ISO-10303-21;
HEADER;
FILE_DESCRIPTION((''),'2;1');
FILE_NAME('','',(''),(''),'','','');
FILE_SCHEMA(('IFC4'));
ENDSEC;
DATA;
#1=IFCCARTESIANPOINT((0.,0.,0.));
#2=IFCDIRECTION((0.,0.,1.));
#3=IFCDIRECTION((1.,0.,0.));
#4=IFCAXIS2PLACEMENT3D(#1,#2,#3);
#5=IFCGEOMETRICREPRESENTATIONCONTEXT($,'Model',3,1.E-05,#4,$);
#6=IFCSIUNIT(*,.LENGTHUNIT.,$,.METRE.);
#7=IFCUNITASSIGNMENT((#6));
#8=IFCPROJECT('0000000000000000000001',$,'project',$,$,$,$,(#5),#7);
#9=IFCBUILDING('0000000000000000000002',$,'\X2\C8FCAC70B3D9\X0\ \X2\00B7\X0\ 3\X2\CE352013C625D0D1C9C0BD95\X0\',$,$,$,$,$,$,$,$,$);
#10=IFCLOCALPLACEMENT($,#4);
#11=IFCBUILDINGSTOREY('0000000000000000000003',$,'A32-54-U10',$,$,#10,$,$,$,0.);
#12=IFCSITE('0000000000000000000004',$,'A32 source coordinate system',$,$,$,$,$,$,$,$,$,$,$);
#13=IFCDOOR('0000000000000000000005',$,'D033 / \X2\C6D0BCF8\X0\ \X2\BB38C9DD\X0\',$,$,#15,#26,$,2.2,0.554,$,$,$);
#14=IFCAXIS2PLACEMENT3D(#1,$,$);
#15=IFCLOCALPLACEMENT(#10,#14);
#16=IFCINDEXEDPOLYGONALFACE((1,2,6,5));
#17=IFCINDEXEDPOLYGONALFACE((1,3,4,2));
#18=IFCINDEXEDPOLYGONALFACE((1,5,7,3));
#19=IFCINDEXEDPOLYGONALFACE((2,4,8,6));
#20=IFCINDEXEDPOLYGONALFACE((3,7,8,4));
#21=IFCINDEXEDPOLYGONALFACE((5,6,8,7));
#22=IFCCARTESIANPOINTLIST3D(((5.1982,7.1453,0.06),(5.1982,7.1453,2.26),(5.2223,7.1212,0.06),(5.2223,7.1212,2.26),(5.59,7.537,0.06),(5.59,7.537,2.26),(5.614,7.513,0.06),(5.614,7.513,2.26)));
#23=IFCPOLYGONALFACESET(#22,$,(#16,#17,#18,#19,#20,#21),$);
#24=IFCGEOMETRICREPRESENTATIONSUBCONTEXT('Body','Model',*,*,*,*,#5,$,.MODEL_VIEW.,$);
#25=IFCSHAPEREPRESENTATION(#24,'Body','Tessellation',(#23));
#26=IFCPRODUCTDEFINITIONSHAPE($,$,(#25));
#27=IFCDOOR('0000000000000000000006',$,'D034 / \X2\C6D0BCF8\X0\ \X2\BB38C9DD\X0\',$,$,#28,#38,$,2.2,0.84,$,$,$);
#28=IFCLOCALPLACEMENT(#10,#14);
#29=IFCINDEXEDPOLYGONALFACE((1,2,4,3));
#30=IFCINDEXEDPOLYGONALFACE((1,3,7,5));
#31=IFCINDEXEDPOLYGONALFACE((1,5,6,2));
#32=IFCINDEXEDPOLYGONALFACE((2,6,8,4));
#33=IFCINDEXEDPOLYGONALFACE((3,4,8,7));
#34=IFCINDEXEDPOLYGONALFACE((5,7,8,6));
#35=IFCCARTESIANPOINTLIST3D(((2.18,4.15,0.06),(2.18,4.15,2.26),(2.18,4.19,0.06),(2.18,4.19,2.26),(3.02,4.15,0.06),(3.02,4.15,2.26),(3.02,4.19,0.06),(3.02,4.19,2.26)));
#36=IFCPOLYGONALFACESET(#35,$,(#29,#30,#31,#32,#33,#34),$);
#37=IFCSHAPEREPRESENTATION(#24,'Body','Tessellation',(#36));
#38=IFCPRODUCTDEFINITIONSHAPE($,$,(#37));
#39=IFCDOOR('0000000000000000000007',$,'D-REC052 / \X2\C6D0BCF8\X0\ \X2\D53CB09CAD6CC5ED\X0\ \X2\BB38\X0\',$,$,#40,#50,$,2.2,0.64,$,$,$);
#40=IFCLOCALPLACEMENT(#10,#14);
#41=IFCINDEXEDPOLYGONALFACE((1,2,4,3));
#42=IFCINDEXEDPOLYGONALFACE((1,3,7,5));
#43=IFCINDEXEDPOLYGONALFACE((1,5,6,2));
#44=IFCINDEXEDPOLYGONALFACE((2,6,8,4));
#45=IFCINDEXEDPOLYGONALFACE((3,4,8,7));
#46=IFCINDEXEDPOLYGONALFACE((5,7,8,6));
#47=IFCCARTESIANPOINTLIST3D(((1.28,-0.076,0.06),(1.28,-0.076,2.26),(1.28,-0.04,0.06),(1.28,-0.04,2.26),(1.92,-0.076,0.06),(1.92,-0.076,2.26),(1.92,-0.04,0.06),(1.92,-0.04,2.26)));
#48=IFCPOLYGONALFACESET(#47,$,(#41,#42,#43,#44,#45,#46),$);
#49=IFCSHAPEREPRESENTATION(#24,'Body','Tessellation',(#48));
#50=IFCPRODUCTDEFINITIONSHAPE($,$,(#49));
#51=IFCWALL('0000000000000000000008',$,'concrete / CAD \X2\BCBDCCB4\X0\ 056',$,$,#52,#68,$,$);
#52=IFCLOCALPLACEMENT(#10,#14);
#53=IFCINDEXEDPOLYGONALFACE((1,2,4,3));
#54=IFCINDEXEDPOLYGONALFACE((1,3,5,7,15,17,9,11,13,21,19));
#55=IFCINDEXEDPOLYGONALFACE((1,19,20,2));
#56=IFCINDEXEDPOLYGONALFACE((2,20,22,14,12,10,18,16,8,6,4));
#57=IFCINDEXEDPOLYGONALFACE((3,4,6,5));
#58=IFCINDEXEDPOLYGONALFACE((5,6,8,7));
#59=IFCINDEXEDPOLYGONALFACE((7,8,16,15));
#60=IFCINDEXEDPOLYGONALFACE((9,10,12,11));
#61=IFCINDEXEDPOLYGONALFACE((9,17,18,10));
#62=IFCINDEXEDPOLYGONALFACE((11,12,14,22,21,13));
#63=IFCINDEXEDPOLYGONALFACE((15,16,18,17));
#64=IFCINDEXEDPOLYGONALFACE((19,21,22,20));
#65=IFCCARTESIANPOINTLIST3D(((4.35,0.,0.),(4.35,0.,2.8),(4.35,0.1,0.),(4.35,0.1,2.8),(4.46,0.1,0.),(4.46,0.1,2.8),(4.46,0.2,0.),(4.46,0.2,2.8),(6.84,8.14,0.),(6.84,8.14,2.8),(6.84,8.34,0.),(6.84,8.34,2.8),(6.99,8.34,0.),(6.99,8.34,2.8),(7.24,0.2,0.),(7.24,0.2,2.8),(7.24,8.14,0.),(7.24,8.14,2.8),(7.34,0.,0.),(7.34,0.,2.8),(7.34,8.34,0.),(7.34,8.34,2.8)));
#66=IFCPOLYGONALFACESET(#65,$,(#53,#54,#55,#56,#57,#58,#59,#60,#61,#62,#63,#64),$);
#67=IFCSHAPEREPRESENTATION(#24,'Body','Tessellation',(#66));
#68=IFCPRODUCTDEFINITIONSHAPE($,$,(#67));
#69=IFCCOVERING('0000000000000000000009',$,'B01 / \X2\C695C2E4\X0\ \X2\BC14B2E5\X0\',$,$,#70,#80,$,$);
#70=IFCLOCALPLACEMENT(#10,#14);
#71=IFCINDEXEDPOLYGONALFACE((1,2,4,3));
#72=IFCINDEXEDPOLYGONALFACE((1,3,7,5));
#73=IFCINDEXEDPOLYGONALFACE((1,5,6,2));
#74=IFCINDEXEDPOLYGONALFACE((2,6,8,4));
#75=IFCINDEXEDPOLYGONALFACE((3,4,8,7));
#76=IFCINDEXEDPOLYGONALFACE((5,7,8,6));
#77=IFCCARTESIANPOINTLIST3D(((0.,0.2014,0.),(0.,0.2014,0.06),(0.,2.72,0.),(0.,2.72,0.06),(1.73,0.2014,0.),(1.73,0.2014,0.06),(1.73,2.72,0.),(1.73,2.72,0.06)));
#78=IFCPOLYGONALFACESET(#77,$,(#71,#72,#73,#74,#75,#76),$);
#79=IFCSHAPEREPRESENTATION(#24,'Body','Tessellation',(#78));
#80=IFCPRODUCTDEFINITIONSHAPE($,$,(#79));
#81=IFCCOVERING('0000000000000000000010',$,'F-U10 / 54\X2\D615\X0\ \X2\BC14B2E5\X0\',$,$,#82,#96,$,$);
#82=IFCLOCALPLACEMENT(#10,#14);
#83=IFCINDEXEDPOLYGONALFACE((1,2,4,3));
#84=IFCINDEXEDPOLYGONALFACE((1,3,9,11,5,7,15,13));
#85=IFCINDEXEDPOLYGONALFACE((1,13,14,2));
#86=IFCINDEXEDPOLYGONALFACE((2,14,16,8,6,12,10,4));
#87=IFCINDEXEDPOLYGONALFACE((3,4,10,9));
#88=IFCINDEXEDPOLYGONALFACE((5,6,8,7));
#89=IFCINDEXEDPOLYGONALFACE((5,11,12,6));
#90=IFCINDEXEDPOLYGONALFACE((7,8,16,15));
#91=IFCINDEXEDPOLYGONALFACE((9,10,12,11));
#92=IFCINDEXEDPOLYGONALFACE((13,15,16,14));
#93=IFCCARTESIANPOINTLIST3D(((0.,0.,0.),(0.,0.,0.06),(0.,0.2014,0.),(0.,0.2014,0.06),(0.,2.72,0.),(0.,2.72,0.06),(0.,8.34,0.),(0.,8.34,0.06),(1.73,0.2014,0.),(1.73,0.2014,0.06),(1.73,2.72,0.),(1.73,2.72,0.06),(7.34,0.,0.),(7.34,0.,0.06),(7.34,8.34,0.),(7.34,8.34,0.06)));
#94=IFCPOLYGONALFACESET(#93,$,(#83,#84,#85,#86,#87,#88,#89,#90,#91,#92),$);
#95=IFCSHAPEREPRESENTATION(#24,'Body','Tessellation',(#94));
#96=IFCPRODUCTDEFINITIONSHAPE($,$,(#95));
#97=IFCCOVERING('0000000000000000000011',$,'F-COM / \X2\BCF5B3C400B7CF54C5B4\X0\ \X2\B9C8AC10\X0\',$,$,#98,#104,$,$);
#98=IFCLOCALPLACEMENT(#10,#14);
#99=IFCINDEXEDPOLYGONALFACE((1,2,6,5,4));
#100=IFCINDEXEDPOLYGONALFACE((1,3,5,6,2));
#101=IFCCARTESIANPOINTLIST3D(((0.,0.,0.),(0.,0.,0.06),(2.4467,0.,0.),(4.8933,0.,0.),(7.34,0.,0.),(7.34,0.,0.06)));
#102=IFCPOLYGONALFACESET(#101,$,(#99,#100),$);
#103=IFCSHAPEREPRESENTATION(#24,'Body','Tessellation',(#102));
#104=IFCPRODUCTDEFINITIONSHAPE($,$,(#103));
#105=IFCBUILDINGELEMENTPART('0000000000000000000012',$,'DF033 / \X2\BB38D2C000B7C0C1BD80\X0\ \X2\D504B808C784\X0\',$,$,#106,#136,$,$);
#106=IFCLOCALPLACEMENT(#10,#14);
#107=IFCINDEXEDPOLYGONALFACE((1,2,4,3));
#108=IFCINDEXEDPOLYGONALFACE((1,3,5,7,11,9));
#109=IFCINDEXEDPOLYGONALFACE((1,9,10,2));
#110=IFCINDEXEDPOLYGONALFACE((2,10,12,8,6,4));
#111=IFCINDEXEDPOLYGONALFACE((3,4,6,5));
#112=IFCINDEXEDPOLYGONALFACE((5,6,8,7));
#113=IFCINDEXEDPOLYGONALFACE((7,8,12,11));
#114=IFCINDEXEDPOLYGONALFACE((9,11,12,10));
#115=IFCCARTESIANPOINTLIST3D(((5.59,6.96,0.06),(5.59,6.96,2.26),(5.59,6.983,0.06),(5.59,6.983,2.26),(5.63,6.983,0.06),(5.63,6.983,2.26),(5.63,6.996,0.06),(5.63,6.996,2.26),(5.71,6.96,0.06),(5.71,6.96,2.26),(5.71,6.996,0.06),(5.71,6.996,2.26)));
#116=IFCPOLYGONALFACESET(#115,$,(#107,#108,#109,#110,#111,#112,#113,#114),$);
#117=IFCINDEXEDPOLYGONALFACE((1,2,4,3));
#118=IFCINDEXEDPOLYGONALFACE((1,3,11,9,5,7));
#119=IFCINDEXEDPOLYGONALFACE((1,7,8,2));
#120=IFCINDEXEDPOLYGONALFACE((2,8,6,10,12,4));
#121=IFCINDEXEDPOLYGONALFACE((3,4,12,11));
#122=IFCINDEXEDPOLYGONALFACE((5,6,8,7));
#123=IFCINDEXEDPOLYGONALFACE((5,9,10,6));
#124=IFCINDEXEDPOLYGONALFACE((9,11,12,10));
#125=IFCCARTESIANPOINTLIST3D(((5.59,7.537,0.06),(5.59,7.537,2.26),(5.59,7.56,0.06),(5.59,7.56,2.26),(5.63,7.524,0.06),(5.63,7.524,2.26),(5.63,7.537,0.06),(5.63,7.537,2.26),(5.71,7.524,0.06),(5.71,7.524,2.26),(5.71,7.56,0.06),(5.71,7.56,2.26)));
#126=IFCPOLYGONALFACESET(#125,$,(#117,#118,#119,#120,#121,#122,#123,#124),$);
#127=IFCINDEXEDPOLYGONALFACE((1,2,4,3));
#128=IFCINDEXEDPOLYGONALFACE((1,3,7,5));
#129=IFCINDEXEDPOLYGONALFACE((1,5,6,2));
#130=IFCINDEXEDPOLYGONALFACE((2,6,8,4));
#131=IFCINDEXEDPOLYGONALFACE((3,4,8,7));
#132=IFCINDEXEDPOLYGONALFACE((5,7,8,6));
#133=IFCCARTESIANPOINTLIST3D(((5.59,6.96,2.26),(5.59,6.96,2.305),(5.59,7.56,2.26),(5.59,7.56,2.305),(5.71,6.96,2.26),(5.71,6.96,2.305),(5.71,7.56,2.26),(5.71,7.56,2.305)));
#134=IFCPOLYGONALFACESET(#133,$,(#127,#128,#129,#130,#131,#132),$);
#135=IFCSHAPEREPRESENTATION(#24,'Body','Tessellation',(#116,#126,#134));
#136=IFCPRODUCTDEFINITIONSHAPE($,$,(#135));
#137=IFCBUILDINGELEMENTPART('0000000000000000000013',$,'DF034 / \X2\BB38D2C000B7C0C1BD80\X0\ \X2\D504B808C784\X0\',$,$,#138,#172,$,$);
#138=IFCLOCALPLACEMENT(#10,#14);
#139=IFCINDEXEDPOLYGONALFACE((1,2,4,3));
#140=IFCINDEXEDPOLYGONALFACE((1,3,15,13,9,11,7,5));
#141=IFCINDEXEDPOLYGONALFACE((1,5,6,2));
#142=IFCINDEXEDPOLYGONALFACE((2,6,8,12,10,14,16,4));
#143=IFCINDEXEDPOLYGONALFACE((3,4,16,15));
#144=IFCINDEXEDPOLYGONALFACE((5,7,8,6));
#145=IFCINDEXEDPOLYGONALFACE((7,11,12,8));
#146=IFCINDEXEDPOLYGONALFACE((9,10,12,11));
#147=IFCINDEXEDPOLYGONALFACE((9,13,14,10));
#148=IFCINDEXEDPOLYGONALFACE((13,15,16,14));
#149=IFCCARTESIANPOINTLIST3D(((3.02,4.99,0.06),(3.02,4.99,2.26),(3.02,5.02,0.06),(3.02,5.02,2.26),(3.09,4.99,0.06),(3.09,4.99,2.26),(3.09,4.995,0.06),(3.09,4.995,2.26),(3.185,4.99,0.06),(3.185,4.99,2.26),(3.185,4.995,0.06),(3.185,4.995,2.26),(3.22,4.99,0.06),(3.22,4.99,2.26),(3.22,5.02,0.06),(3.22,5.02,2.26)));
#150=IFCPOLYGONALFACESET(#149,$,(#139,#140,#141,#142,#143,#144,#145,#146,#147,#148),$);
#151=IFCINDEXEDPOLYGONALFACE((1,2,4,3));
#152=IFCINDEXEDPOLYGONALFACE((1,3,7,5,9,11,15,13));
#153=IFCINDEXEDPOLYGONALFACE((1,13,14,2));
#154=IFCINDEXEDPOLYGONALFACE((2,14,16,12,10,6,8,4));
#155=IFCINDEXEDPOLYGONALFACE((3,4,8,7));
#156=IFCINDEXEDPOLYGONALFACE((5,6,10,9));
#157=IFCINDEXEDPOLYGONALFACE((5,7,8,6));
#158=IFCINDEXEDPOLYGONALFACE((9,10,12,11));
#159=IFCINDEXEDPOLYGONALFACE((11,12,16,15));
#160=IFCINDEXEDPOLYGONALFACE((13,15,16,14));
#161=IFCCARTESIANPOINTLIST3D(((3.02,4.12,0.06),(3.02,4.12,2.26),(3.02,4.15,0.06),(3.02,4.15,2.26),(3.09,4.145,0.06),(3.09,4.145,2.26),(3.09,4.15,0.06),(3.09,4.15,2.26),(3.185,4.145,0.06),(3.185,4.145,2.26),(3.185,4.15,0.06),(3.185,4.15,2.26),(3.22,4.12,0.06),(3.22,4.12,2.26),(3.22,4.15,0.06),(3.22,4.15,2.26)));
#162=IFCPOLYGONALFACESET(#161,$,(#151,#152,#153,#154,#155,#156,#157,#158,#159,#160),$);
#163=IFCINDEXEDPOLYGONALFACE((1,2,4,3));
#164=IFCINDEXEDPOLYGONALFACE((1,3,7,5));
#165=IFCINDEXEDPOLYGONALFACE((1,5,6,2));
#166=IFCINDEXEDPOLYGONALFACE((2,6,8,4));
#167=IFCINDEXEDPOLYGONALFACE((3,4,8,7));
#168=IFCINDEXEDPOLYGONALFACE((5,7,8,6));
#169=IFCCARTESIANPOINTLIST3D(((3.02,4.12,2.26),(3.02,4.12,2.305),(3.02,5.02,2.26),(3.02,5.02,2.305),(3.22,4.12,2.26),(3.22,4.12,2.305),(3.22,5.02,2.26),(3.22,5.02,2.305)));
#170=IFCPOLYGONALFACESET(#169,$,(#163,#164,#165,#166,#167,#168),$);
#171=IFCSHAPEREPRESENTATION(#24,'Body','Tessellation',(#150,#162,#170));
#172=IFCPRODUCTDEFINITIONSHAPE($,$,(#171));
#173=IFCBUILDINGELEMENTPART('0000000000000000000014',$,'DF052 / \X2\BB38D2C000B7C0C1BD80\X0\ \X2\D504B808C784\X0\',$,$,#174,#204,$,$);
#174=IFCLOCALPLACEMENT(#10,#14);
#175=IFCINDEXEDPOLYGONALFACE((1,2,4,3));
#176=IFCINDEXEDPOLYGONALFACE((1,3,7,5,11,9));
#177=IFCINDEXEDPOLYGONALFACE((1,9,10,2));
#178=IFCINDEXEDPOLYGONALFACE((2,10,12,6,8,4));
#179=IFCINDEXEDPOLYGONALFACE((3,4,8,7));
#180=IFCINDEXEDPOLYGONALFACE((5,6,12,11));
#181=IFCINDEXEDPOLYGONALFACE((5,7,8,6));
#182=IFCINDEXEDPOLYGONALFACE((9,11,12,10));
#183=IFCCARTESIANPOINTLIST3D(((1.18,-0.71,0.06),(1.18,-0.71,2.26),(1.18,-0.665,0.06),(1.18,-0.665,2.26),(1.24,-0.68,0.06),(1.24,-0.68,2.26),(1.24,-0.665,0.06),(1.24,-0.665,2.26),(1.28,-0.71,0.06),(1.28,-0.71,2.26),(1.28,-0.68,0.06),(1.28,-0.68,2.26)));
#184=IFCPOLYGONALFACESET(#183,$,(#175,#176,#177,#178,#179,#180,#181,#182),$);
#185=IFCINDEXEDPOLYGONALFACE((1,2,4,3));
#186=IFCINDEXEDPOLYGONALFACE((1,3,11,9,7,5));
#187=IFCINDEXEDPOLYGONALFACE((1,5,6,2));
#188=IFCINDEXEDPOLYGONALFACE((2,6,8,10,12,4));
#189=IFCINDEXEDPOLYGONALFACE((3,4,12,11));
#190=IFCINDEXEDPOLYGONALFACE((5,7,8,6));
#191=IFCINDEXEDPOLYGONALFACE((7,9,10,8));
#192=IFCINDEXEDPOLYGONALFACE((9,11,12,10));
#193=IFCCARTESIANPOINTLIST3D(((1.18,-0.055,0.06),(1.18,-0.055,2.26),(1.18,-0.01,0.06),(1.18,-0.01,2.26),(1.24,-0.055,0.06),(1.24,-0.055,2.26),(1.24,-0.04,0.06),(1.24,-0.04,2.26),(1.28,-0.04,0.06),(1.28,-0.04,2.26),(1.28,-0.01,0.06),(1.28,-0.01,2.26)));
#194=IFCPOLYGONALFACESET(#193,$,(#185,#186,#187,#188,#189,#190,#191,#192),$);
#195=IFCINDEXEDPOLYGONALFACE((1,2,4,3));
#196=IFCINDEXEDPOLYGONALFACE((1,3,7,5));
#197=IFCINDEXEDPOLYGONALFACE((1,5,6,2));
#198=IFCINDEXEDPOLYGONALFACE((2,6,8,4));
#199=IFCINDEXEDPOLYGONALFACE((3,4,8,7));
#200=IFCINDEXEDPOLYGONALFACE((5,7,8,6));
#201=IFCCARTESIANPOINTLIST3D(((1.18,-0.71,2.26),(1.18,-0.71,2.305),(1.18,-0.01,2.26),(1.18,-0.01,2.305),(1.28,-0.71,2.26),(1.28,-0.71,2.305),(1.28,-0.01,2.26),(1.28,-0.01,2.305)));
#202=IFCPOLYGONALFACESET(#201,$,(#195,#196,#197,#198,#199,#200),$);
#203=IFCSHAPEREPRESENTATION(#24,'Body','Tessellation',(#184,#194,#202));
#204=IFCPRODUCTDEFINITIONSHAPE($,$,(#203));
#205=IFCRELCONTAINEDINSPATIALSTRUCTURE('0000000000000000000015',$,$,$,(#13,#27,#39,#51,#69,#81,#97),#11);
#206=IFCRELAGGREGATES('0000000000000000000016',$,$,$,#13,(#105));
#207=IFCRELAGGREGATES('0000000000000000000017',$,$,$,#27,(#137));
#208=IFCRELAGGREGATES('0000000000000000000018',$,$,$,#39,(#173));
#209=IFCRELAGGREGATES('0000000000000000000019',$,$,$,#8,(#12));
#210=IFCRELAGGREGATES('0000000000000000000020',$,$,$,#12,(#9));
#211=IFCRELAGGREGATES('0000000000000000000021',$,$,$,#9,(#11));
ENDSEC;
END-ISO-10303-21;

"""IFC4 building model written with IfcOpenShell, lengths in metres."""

from ifc_helpers import new_model, si_unit, frame, origin, origin_with_axes, place, context, subcontext, project, spatial, polyline, outline, extrude, element, aggregate, save


model = new_model("IFC4")

# Units and contexts
model_context = context("Model", 3, precision=1e-05, world=origin_with_axes())
body_context = subcontext(model_context, "Body", "Model", "MODEL_VIEW")
ifc_project = project(units=[si_unit("LENGTHUNIT", "METRE")], contexts=[model_context])

# Site, building, storey
storey_placement = place(None, origin_with_axes())
site = spatial("IfcSite", under=ifc_project, Name="A32 source coordinate system")
building = spatial("IfcBuilding", under=site, Name="주거동 · 3층–옥탑지붕")
storey = spatial("IfcBuildingStorey", under=building, at=storey_placement, Name="A32-54-U10", Elevation=0.0)

# Doors
door_1_placement = place(storey_placement, origin_with_axes())
door_1 = element("IfcDoor", 1, at=door_1_placement, inside=storey, Name="D033 / 원본 문짝", OverallHeight=2.2, OverallWidth=0.554, context=body_context, shape_type="SweptSolid", body=[
    extrude(outline(polyline([(5.2223, 7.1212), (5.1982, 7.1453), (5.59, 7.537), (5.614, 7.513), (5.2223, 7.1212)])), frame((0.0, 0.0, 0.06)), (0.0, 0.0, 1.0), 2.2),
])
door_2_placement = place(storey_placement, origin_with_axes())
door_2 = element("IfcDoor", 2, at=door_2_placement, inside=storey, Name="D034 / 원본 문짝", OverallHeight=2.2, OverallWidth=0.84, context=body_context, shape_type="SweptSolid", body=[
    extrude(outline(polyline([(3.02, 4.15), (2.18, 4.15), (2.18, 4.19), (3.02, 4.19), (3.02, 4.15)])), frame((0.0, 0.0, 0.06)), (0.0, 0.0, 1.0), 2.2),
])
door_3_placement = place(storey_placement, origin_with_axes())
door_3 = element("IfcDoor", 3, at=door_3_placement, inside=storey, Name="D-REC052 / 원본 피난구역 문", OverallHeight=2.2, OverallWidth=0.64, context=body_context, shape_type="SweptSolid", body=[
    extrude(outline(polyline([(1.92, -0.076), (1.28, -0.076), (1.28, -0.04), (1.92, -0.04), (1.92, -0.076)])), frame((0.0, 0.0, 0.06)), (0.0, 0.0, 1.0), 2.2),
])

# Wall
wall_placement = place(storey_placement, origin_with_axes())
element("IfcWall", 4, at=wall_placement, inside=storey, Name="concrete / CAD 벽체 056", context=body_context, shape_type="SweptSolid", body=[
    extrude(outline(polyline([(7.24, 0.2), (7.24, 8.14), (6.84, 8.14), (6.84, 8.34), (6.99, 8.34), (6.99, 8.34), (7.34, 8.34), (7.34, 0.0), (4.35, 0.0), (4.35, 0.1), (4.46, 0.1), (4.46, 0.2), (7.24, 0.2)])), origin(), (0.0, 0.0, 1.0), 2.8),
])

# Coverings
covering_1_placement = place(storey_placement, origin_with_axes())
element("IfcCovering", 5, at=covering_1_placement, inside=storey, Name="B01 / 욕실 바닥", context=body_context, shape_type="SweptSolid", body=[
    extrude(outline(polyline([(0.0, 0.2014), (0.0, 2.72), (1.73, 2.72), (1.73, 0.2014), (0.0, 0.2014)])), origin(), (0.0, 0.0, 1.0), 0.06),
])
covering_2_placement = place(storey_placement, origin_with_axes())
element("IfcCovering", 6, at=covering_2_placement, inside=storey, Name="F-U10 / 54형 바닥", context=body_context, shape_type="SweptSolid", body=[
    extrude(outline(polyline([(7.34, 0.0), (0.0, 0.0), (0.0, 0.2014), (1.73, 0.2014), (1.73, 2.72), (0.0, 2.72), (0.0, 8.34), (7.34, 8.34), (7.34, 0.0)])), origin(), (0.0, 0.0, 1.0), 0.06),
])
covering_3_placement = place(storey_placement, origin_with_axes())
element("IfcCovering", 7, at=covering_3_placement, inside=storey, Name="F-COM / 복도·코어 마감", context=body_context, shape_type="SweptSolid", body=[
    extrude(outline(polyline([(7.34, 0.0), (7.34, 0.0), (0.0, 0.0), (0.0, 0.0), (7.34, 0.0)])), origin(), (0.0, 0.0, 1.0), 0.06),
])

# Building element parts
building_element_part_1_placement = place(door_1_placement, origin_with_axes())
building_element_part_1 = element("IfcBuildingElementPart", 8, at=building_element_part_1_placement, Name="DF033 / 문틀·상부 프레임", context=body_context, shape_type="SweptSolid", body=[
    extrude(outline(polyline([(5.59, 6.96), (5.59, 6.983), (5.63, 6.983), (5.63, 6.996), (5.71, 6.996), (5.71, 6.96), (5.59, 6.96)])), frame((0.0, 0.0, 0.06)), (0.0, 0.0, 1.0), 2.2),
    extrude(outline(polyline([(5.71, 7.524), (5.63, 7.524), (5.63, 7.537), (5.59, 7.537), (5.59, 7.56), (5.71, 7.56), (5.71, 7.524)])), frame((0.0, 0.0, 0.06)), (0.0, 0.0, 1.0), 2.2),
    extrude(outline(polyline([(5.59, 6.96), (5.59, 7.56), (5.71, 7.56), (5.71, 6.96), (5.59, 6.96)])), frame((0.0, 0.0, 2.26)), (0.0, 0.0, 1.0), 0.045),
])
aggregate(door_1, [building_element_part_1])
building_element_part_2_placement = place(door_2_placement, origin_with_axes())
building_element_part_2 = element("IfcBuildingElementPart", 9, at=building_element_part_2_placement, Name="DF034 / 문틀·상부 프레임", context=body_context, shape_type="SweptSolid", body=[
    extrude(outline(polyline([(3.22, 5.02), (3.22, 4.99), (3.185, 4.99), (3.185, 4.995), (3.09, 4.995), (3.09, 4.99), (3.02, 4.99), (3.02, 5.02), (3.22, 5.02)])), frame((0.0, 0.0, 0.06)), (0.0, 0.0, 1.0), 2.2),
    extrude(outline(polyline([(3.02, 4.15), (3.09, 4.15), (3.09, 4.145), (3.185, 4.145), (3.185, 4.15), (3.22, 4.15), (3.22, 4.12), (3.02, 4.12), (3.02, 4.15)])), frame((0.0, 0.0, 0.06)), (0.0, 0.0, 1.0), 2.2),
    extrude(outline(polyline([(3.02, 4.12), (3.02, 5.02), (3.22, 5.02), (3.22, 4.12), (3.02, 4.12)])), frame((0.0, 0.0, 2.26)), (0.0, 0.0, 1.0), 0.045),
])
aggregate(door_2, [building_element_part_2])
building_element_part_3_placement = place(door_3_placement, origin_with_axes())
building_element_part_3 = element("IfcBuildingElementPart", 10, at=building_element_part_3_placement, Name="DF052 / 문틀·상부 프레임", context=body_context, shape_type="SweptSolid", body=[
    extrude(outline(polyline([(1.18, -0.71), (1.18, -0.665), (1.24, -0.665), (1.24, -0.68), (1.28, -0.68), (1.28, -0.71), (1.18, -0.71)])), frame((0.0, 0.0, 0.06)), (0.0, 0.0, 1.0), 2.2),
    extrude(outline(polyline([(1.28, -0.04), (1.24, -0.04), (1.24, -0.055), (1.18, -0.055), (1.18, -0.01), (1.28, -0.01), (1.28, -0.04)])), frame((0.0, 0.0, 0.06)), (0.0, 0.0, 1.0), 2.2),
    extrude(outline(polyline([(1.18, -0.71), (1.18, -0.01), (1.28, -0.01), (1.28, -0.71), (1.18, -0.71)])), frame((0.0, 0.0, 2.26)), (0.0, 0.0, 1.0), 0.045),
])
aggregate(door_3, [building_element_part_3])

save(model, "model.ifc")
